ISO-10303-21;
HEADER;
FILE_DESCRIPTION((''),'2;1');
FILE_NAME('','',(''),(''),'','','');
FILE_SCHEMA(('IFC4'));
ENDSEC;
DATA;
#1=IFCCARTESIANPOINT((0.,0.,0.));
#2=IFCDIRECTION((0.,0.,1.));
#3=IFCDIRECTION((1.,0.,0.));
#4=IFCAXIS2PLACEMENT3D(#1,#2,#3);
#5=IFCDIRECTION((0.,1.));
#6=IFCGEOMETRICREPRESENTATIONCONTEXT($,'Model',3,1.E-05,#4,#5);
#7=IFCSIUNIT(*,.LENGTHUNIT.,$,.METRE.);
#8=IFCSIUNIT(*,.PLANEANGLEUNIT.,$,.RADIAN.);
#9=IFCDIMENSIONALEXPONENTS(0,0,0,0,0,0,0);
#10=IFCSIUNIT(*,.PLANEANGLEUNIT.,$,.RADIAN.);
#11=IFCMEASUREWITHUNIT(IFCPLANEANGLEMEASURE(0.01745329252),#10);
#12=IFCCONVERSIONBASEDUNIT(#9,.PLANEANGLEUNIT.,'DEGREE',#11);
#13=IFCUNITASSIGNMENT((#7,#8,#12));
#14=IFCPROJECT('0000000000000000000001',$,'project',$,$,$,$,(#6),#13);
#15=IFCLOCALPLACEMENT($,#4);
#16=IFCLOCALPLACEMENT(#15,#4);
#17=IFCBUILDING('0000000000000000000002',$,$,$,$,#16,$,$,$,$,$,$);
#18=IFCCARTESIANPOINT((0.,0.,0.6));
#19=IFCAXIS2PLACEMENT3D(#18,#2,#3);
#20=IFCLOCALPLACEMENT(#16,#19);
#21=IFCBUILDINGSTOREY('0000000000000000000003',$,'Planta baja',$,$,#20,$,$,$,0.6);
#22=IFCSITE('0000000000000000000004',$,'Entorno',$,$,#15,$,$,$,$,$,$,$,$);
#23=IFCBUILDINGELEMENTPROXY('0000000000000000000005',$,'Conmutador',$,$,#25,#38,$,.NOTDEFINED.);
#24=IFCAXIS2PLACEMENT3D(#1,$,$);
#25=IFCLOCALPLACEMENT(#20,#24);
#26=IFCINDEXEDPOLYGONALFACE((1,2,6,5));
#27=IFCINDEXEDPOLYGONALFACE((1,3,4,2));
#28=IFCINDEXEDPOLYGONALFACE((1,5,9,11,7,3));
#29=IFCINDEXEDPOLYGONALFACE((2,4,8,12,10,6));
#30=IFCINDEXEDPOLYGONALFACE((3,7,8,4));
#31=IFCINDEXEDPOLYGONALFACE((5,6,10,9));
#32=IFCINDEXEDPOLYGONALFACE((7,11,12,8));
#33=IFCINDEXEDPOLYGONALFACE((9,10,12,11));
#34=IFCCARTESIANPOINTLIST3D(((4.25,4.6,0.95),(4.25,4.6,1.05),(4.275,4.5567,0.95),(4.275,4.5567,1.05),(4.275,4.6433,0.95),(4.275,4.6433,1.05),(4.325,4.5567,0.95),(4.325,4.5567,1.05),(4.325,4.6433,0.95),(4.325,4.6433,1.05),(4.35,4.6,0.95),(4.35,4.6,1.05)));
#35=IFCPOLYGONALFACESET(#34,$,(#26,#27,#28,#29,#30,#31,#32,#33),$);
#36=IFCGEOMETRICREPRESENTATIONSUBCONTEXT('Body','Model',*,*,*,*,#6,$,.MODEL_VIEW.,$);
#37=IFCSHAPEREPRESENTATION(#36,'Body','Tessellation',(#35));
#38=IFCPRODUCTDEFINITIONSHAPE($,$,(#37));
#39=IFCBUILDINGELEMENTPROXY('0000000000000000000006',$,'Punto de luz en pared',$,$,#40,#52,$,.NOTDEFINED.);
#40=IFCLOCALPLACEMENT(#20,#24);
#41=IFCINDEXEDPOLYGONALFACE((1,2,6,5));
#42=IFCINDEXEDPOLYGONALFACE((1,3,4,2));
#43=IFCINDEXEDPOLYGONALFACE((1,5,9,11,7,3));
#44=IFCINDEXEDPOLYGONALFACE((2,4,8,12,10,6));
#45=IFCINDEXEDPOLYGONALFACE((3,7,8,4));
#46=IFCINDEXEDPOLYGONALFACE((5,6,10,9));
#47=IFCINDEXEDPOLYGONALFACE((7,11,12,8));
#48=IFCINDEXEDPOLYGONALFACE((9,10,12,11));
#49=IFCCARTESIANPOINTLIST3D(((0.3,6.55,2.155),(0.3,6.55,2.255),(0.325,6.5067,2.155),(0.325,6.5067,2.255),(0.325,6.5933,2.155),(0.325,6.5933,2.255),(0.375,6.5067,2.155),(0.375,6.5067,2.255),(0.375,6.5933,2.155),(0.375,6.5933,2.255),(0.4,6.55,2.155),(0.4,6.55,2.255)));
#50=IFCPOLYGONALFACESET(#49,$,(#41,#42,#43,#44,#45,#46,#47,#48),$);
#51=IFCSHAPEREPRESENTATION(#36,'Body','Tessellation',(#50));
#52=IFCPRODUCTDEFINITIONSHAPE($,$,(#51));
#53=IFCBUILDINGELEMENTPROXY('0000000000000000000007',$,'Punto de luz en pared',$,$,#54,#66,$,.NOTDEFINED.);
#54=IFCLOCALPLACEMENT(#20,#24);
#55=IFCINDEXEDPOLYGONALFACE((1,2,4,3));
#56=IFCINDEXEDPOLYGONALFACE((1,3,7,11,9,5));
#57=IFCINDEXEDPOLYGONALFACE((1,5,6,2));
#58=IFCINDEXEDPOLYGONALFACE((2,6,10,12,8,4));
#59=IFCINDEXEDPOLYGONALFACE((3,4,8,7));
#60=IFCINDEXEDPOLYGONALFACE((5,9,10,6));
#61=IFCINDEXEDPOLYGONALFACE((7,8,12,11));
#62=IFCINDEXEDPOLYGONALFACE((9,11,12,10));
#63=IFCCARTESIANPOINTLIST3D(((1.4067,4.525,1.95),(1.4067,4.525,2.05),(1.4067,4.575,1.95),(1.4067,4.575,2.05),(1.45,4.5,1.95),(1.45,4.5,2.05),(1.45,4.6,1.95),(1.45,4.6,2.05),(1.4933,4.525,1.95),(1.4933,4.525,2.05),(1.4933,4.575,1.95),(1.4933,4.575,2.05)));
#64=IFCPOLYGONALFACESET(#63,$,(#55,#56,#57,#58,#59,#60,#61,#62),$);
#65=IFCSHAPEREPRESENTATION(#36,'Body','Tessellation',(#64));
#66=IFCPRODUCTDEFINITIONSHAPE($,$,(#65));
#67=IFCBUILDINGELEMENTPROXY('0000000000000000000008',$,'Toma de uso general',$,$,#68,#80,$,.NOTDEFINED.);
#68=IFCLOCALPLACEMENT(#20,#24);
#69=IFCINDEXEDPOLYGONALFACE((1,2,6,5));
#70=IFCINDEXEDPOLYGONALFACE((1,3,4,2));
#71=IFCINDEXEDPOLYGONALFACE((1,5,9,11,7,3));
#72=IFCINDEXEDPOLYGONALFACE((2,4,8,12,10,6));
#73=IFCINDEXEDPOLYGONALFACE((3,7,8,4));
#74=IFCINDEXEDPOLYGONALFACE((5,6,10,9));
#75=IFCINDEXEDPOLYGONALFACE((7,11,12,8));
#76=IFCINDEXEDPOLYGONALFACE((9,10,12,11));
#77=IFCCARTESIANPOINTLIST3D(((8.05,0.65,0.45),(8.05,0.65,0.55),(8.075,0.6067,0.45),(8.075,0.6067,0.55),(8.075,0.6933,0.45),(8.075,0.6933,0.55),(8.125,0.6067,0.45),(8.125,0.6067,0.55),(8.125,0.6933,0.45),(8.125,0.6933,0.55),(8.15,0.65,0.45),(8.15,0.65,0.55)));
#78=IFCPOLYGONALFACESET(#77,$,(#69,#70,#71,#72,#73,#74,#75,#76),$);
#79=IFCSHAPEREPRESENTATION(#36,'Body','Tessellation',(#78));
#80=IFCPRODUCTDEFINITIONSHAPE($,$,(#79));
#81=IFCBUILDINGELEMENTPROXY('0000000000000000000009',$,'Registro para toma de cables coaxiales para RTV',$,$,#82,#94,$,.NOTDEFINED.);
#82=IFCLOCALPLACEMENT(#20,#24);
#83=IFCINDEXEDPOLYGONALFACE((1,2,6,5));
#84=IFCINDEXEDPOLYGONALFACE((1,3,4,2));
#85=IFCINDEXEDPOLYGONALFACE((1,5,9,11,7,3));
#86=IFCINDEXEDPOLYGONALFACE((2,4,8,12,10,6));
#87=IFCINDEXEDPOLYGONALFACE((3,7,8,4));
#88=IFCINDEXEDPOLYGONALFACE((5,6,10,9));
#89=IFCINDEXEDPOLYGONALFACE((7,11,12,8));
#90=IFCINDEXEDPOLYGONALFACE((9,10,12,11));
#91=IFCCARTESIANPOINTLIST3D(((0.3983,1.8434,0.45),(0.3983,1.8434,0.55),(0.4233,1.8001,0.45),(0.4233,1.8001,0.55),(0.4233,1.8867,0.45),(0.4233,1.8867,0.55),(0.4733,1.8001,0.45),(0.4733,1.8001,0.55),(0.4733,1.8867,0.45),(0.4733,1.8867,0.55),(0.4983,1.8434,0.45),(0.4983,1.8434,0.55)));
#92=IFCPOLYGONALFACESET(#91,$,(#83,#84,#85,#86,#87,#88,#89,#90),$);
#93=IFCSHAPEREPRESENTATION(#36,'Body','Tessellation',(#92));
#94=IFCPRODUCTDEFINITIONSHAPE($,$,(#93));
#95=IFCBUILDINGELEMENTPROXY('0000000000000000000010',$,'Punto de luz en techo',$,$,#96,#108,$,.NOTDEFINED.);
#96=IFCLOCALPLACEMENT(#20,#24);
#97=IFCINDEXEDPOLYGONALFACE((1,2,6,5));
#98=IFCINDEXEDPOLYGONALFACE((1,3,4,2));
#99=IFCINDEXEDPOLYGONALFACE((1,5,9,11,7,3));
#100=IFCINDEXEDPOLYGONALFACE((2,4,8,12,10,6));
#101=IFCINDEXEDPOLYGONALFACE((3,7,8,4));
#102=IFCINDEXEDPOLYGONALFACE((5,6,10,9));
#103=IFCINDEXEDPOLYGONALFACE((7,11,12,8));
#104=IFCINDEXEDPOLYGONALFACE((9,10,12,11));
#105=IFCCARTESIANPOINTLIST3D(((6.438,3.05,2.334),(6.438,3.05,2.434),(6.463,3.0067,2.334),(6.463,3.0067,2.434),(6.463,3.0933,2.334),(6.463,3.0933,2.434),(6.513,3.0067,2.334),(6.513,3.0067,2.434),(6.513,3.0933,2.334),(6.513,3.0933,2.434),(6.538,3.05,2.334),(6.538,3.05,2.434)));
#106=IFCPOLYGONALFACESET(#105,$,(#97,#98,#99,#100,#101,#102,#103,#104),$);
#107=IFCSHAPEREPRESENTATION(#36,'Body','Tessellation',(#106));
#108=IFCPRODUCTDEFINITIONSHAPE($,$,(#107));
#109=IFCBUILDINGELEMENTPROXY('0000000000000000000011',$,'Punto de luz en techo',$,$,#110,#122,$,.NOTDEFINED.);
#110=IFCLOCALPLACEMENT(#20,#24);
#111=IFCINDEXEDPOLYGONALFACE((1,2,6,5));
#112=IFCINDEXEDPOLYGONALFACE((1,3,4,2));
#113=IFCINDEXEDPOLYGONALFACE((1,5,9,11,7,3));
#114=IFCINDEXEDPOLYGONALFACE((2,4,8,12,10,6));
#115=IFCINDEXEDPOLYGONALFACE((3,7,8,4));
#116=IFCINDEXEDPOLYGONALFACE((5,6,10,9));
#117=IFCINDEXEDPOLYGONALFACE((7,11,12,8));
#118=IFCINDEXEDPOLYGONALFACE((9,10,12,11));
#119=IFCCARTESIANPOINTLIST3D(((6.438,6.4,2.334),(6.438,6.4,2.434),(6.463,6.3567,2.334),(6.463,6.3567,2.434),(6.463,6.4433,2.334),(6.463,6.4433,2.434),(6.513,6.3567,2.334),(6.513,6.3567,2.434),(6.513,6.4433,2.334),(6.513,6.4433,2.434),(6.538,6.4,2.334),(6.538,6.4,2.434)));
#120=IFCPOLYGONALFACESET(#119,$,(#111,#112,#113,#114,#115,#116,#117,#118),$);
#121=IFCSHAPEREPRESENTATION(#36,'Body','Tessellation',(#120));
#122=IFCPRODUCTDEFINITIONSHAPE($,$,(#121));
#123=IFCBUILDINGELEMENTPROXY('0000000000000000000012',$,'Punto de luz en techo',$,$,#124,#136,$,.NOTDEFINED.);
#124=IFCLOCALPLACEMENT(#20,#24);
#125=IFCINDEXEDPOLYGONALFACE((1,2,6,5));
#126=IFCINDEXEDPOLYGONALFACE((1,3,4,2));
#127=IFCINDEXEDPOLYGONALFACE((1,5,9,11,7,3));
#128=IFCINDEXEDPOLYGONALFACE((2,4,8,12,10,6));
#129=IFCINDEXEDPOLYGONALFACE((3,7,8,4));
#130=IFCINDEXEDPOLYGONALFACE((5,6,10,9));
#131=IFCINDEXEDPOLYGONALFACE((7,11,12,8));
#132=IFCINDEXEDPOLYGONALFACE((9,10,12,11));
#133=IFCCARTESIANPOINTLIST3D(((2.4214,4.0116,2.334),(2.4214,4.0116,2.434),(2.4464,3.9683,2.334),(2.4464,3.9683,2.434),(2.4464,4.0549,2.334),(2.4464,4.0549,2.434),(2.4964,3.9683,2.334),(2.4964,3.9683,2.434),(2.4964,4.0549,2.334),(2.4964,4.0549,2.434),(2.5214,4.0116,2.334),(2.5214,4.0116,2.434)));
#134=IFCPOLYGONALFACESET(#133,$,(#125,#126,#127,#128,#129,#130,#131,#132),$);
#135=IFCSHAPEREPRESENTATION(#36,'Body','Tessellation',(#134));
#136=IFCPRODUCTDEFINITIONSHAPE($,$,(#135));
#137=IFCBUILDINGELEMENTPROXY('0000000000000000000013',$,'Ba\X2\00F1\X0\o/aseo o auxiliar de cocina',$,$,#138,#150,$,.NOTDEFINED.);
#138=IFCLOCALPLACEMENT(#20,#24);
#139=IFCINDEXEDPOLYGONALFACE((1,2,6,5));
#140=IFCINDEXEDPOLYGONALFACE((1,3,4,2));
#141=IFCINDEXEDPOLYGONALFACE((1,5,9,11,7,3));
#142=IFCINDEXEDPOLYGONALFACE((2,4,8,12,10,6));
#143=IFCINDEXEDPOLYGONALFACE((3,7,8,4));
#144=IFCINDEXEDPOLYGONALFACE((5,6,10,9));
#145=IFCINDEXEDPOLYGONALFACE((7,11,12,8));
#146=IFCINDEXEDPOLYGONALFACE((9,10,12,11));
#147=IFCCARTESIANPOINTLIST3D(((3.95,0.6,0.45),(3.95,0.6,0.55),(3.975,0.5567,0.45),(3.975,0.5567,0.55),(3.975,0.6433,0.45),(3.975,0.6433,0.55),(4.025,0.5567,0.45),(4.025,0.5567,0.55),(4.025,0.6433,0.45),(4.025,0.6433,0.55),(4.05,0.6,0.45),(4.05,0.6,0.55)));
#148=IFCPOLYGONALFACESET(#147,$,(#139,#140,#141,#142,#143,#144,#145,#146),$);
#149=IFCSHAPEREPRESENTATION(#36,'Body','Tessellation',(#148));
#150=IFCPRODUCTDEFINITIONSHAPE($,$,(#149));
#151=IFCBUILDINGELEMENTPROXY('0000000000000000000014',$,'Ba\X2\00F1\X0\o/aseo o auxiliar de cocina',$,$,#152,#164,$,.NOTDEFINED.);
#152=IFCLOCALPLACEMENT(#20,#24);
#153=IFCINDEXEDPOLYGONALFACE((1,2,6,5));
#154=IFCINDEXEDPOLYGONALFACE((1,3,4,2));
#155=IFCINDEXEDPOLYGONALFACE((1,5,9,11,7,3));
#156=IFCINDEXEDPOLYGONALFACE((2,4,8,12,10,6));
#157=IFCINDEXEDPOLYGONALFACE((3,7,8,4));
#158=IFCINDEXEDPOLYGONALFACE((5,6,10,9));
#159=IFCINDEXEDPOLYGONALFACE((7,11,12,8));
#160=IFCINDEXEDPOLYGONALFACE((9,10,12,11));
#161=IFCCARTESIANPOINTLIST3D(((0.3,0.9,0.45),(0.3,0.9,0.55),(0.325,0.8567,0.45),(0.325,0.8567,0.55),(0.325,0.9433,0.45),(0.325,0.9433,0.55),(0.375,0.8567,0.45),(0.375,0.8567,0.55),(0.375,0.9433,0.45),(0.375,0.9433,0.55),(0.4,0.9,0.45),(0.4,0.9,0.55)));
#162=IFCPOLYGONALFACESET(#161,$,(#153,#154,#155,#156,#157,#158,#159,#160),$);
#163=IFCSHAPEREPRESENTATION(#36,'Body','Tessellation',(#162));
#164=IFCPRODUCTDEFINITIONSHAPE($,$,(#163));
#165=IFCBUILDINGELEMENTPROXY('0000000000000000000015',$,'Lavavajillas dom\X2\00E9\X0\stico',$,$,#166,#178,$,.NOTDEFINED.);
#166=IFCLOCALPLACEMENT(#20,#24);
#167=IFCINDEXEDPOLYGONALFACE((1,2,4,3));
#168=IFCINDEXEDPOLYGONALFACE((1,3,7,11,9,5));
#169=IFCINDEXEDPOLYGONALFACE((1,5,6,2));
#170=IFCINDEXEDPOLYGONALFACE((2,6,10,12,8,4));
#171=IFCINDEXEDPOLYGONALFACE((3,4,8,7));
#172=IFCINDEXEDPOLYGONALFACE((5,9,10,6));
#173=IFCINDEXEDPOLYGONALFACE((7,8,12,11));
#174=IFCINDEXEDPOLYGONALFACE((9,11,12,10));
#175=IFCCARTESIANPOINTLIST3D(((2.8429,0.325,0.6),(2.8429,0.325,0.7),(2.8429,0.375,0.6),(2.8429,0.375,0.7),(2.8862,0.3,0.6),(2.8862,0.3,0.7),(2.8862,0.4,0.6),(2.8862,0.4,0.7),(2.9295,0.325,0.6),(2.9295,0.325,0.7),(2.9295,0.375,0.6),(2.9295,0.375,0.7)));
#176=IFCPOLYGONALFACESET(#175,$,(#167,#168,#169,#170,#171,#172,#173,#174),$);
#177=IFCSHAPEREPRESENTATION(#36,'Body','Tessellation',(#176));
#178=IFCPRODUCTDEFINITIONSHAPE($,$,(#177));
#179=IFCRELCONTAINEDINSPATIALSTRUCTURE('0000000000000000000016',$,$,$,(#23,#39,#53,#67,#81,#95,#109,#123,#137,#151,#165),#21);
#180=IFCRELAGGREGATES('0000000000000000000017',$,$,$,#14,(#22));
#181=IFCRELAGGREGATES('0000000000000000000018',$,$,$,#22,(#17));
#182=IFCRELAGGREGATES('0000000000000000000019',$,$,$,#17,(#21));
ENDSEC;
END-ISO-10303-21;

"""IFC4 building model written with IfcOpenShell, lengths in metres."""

from ifc_helpers import new_model, entity, si_unit, converted_unit, direction, frame, origin_with_axes, place, context, subcontext, project, spatial, polyline, outline, extrude, source, transform, mapped, element, save


model = new_model("IFC4")

# Units and contexts
model_context = context("Model", 3, precision=1e-05, world=origin_with_axes(), true_north=direction((0.0, 1.0)))
body_context = subcontext(model_context, "Body", "Model", "MODEL_VIEW")
ifc_project = project(units=[si_unit("LENGTHUNIT", "METRE"), si_unit("PLANEANGLEUNIT", "RADIAN"), converted_unit("PLANEANGLEUNIT", "DEGREE", entity("IfcPlaneAngleMeasure", 0.01745329252), si_unit("PLANEANGLEUNIT", "RADIAN"), dimensions=[0, 0, 0, 0, 0, 0, 0])], contexts=[model_context])

# Site, building, storey
site_placement = place(None, origin_with_axes())
site = spatial("IfcSite", under=ifc_project, at=site_placement, Name="Entorno")
building_placement = place(site_placement, origin_with_axes())
building = spatial("IfcBuilding", under=site, at=building_placement)
storey_placement = place(building_placement, frame((0.0, 0.0, 0.6), z_axis=(0.0, 0.0, 1.0), x_axis=(1.0, 0.0, 0.0)))
storey = spatial("IfcBuildingStorey", under=building, at=storey_placement, Name="Planta baja", Elevation=0.6)

# Building element proxies
shared_shape_1 = source(origin_with_axes(), body_context, "Body", "SolidModel", [
    extrude(outline(polyline([(0.05, 0.0), (0.025, 0.0433), (-0.025, 0.0433), (-0.05, 0.0), (-0.025, -0.0433), (0.025, -0.0433), (0.05, 0.0)])), frame((0.0, 0.0, -0.05), z_axis=(0.0, 0.0, 1.0), x_axis=(1.0, 0.0, 0.0)), (0.0, 0.0, 1.0), 0.1),
])
proxy_1_placement = place(storey_placement, frame((0.0, 0.0, -0.6), z_axis=(0.0, 0.0, 1.0), x_axis=(1.0, 0.0, 0.0)))
element("IfcBuildingElementProxy", 1, at=proxy_1_placement, inside=storey, Name="Conmutador", PredefinedType="NOTDEFINED", context=body_context, shape_type="Brep", body=[
    mapped(shared_shape_1, transform((4.3, 4.6, 1.6), x_axis=(1.0, 0.0, 0.0), y_axis=(0.0, 1.0, 0.0), z_axis=(0.0, 0.0, 1.0))),
])
shared_shape_2 = source(origin_with_axes(), body_context, "Body", "SolidModel", [
    extrude(outline(polyline([(0.05, 0.0), (0.025, 0.0433), (-0.025, 0.0433), (-0.05, 0.0), (-0.025, -0.0433), (0.025, -0.0433), (0.05, 0.0)])), frame((0.0, 0.0, -0.05), z_axis=(0.0, 0.0, 1.0), x_axis=(1.0, 0.0, 0.0)), (0.0, 0.0, 1.0), 0.1),
])
proxy_2_placement = place(storey_placement, frame((0.0, 0.0, -0.6), z_axis=(0.0, 0.0, 1.0), x_axis=(1.0, 0.0, 0.0)))
element("IfcBuildingElementProxy", 2, at=proxy_2_placement, inside=storey, Name="Punto de luz en pared", PredefinedType="NOTDEFINED", context=body_context, shape_type="Brep", body=[
    mapped(shared_shape_2, transform((0.35, 6.55, 2.805), x_axis=(1.0, 0.0, 0.0), y_axis=(0.0, 1.0, 0.0), z_axis=(0.0, 0.0, 1.0))),
])
proxy_3_placement = place(storey_placement, frame((0.0, 0.0, -0.6), z_axis=(0.0, 0.0, 1.0), x_axis=(1.0, 0.0, 0.0)))
element("IfcBuildingElementProxy", 3, at=proxy_3_placement, inside=storey, Name="Punto de luz en pared", PredefinedType="NOTDEFINED", context=body_context, shape_type="Brep", body=[
    mapped(shared_shape_2, transform((1.45, 4.55, 2.6), x_axis=(0.0, -1.0, 0.0), y_axis=(1.0, 0.0, 0.0), z_axis=(0.0, 0.0, 1.0))),
])
shared_shape_3 = source(origin_with_axes(), body_context, "Body", "SolidModel", [
    extrude(outline(polyline([(0.05, 0.0), (0.025, 0.0433), (-0.025, 0.0433), (-0.05, 0.0), (-0.025, -0.0433), (0.025, -0.0433), (0.05, 0.0)])), frame((0.0, 0.0, -0.05), z_axis=(0.0, 0.0, 1.0), x_axis=(1.0, 0.0, 0.0)), (0.0, 0.0, 1.0), 0.1),
])
proxy_4_placement = place(storey_placement, frame((0.0, 0.0, -0.6), z_axis=(0.0, 0.0, 1.0), x_axis=(1.0, 0.0, 0.0)))
element("IfcBuildingElementProxy", 4, at=proxy_4_placement, inside=storey, Name="Toma de uso general", PredefinedType="NOTDEFINED", context=body_context, shape_type="Brep", body=[
    mapped(shared_shape_3, transform((8.1, 0.65, 1.1), x_axis=(-1.0, 0.0, 0.0), y_axis=(0.0, -1.0, 0.0), z_axis=(0.0, 0.0, 1.0))),
])
shared_shape_4 = source(origin_with_axes(), body_context, "Body", "SolidModel", [
    extrude(outline(polyline([(0.05, 0.0), (0.025, 0.0433), (-0.025, 0.0433), (-0.05, 0.0), (-0.025, -0.0433), (0.025, -0.0433), (0.05, 0.0)])), frame((0.0, 0.0, -0.05), z_axis=(0.0, 0.0, 1.0), x_axis=(1.0, 0.0, 0.0)), (0.0, 0.0, 1.0), 0.1),
])
proxy_5_placement = place(storey_placement, frame((0.0, 0.0, -0.6), z_axis=(0.0, 0.0, 1.0), x_axis=(1.0, 0.0, 0.0)))
element("IfcBuildingElementProxy", 5, at=proxy_5_placement, inside=storey, Name="Registro para toma de cables coaxiales para RTV", PredefinedType="NOTDEFINED", context=body_context, shape_type="Brep", body=[
    mapped(shared_shape_4, transform((0.4483, 1.8434, 1.1), x_axis=(1.0, 0.0, 0.0), y_axis=(0.0, 1.0, 0.0), z_axis=(0.0, 0.0, 1.0))),
])
shared_shape_5 = source(origin_with_axes(), body_context, "Body", "SolidModel", [
    extrude(outline(polyline([(0.05, 0.0), (0.025, 0.0433), (-0.025, 0.0433), (-0.05, 0.0), (-0.025, -0.0433), (0.025, -0.0433), (0.05, 0.0)])), frame((0.0, 0.0, -0.05), z_axis=(0.0, 0.0, 1.0), x_axis=(1.0, 0.0, 0.0)), (0.0, 0.0, 1.0), 0.1),
])
proxy_6_placement = place(storey_placement, frame((0.0, 0.0, -0.6), z_axis=(0.0, 0.0, 1.0), x_axis=(1.0, 0.0, 0.0)))
element("IfcBuildingElementProxy", 6, at=proxy_6_placement, inside=storey, Name="Punto de luz en techo", PredefinedType="NOTDEFINED", context=body_context, shape_type="Brep", body=[
    mapped(shared_shape_5, transform((6.488, 3.05, 2.984), x_axis=(1.0, 0.0, 0.0), y_axis=(0.0, 1.0, 0.0), z_axis=(0.0, 0.0, 1.0))),
])
proxy_7_placement = place(storey_placement, frame((0.0, 0.0, -0.6), z_axis=(0.0, 0.0, 1.0), x_axis=(1.0, 0.0, 0.0)))
element("IfcBuildingElementProxy", 7, at=proxy_7_placement, inside=storey, Name="Punto de luz en techo", PredefinedType="NOTDEFINED", context=body_context, shape_type="Brep", body=[
    mapped(shared_shape_5, transform((6.488, 6.4, 2.984), x_axis=(1.0, 0.0, 0.0), y_axis=(0.0, 1.0, 0.0), z_axis=(0.0, 0.0, 1.0))),
])
proxy_8_placement = place(storey_placement, frame((0.0, 0.0, -0.6), z_axis=(0.0, 0.0, 1.0), x_axis=(1.0, 0.0, 0.0)))
element("IfcBuildingElementProxy", 8, at=proxy_8_placement, inside=storey, Name="Punto de luz en techo", PredefinedType="NOTDEFINED", context=body_context, shape_type="Brep", body=[
    mapped(shared_shape_5, transform((2.4714, 4.0116, 2.984), x_axis=(1.0, 0.0, 0.0), y_axis=(0.0, 1.0, 0.0), z_axis=(0.0, 0.0, 1.0))),
])
shared_shape_6 = source(origin_with_axes(), body_context, "Body", "SolidModel", [
    extrude(outline(polyline([(0.05, 0.0), (0.025, 0.0433), (-0.025, 0.0433), (-0.05, 0.0), (-0.025, -0.0433), (0.025, -0.0433), (0.05, 0.0)])), frame((0.0, 0.0, -0.05), z_axis=(0.0, 0.0, 1.0), x_axis=(1.0, 0.0, 0.0)), (0.0, 0.0, 1.0), 0.1),
])
proxy_9_placement = place(storey_placement, frame((0.0, 0.0, -0.6), z_axis=(0.0, 0.0, 1.0), x_axis=(1.0, 0.0, 0.0)))
element("IfcBuildingElementProxy", 9, at=proxy_9_placement, inside=storey, Name="Baño/aseo o auxiliar de cocina", PredefinedType="NOTDEFINED", context=body_context, shape_type="Brep", body=[
    mapped(shared_shape_6, transform((4.0, 0.6, 1.1), x_axis=(-1.0, 0.0, 0.0), y_axis=(0.0, -1.0, 0.0), z_axis=(0.0, 0.0, 1.0))),
])
proxy_10_placement = place(storey_placement, frame((0.0, 0.0, -0.6), z_axis=(0.0, 0.0, 1.0), x_axis=(1.0, 0.0, 0.0)))
element("IfcBuildingElementProxy", 10, at=proxy_10_placement, inside=storey, Name="Baño/aseo o auxiliar de cocina", PredefinedType="NOTDEFINED", context=body_context, shape_type="Brep", body=[
    mapped(shared_shape_6, transform((0.35, 0.9, 1.1), x_axis=(1.0, 0.0, 0.0), y_axis=(0.0, 1.0, 0.0), z_axis=(0.0, 0.0, 1.0))),
])
shared_shape_7 = source(origin_with_axes(), body_context, "Body", "SolidModel", [
    extrude(outline(polyline([(0.05, 0.0), (0.025, 0.0433), (-0.025, 0.0433), (-0.05, 0.0), (-0.025, -0.0433), (0.025, -0.0433), (0.05, 0.0)])), frame((0.0, 0.0, -0.05), z_axis=(0.0, 0.0, 1.0), x_axis=(1.0, 0.0, 0.0)), (0.0, 0.0, 1.0), 0.1),
])
proxy_11_placement = place(storey_placement, frame((0.0, 0.0, -0.6), z_axis=(0.0, 0.0, 1.0), x_axis=(1.0, 0.0, 0.0)))
element("IfcBuildingElementProxy", 11, at=proxy_11_placement, inside=storey, Name="Lavavajillas doméstico", PredefinedType="NOTDEFINED", context=body_context, shape_type="Brep", body=[
    mapped(shared_shape_7, transform((2.8862, 0.35, 1.25), x_axis=(0.0, 1.0, 0.0), y_axis=(-1.0, 0.0, 0.0), z_axis=(0.0, 0.0, 1.0))),
])

save(model, "model.ifc")
